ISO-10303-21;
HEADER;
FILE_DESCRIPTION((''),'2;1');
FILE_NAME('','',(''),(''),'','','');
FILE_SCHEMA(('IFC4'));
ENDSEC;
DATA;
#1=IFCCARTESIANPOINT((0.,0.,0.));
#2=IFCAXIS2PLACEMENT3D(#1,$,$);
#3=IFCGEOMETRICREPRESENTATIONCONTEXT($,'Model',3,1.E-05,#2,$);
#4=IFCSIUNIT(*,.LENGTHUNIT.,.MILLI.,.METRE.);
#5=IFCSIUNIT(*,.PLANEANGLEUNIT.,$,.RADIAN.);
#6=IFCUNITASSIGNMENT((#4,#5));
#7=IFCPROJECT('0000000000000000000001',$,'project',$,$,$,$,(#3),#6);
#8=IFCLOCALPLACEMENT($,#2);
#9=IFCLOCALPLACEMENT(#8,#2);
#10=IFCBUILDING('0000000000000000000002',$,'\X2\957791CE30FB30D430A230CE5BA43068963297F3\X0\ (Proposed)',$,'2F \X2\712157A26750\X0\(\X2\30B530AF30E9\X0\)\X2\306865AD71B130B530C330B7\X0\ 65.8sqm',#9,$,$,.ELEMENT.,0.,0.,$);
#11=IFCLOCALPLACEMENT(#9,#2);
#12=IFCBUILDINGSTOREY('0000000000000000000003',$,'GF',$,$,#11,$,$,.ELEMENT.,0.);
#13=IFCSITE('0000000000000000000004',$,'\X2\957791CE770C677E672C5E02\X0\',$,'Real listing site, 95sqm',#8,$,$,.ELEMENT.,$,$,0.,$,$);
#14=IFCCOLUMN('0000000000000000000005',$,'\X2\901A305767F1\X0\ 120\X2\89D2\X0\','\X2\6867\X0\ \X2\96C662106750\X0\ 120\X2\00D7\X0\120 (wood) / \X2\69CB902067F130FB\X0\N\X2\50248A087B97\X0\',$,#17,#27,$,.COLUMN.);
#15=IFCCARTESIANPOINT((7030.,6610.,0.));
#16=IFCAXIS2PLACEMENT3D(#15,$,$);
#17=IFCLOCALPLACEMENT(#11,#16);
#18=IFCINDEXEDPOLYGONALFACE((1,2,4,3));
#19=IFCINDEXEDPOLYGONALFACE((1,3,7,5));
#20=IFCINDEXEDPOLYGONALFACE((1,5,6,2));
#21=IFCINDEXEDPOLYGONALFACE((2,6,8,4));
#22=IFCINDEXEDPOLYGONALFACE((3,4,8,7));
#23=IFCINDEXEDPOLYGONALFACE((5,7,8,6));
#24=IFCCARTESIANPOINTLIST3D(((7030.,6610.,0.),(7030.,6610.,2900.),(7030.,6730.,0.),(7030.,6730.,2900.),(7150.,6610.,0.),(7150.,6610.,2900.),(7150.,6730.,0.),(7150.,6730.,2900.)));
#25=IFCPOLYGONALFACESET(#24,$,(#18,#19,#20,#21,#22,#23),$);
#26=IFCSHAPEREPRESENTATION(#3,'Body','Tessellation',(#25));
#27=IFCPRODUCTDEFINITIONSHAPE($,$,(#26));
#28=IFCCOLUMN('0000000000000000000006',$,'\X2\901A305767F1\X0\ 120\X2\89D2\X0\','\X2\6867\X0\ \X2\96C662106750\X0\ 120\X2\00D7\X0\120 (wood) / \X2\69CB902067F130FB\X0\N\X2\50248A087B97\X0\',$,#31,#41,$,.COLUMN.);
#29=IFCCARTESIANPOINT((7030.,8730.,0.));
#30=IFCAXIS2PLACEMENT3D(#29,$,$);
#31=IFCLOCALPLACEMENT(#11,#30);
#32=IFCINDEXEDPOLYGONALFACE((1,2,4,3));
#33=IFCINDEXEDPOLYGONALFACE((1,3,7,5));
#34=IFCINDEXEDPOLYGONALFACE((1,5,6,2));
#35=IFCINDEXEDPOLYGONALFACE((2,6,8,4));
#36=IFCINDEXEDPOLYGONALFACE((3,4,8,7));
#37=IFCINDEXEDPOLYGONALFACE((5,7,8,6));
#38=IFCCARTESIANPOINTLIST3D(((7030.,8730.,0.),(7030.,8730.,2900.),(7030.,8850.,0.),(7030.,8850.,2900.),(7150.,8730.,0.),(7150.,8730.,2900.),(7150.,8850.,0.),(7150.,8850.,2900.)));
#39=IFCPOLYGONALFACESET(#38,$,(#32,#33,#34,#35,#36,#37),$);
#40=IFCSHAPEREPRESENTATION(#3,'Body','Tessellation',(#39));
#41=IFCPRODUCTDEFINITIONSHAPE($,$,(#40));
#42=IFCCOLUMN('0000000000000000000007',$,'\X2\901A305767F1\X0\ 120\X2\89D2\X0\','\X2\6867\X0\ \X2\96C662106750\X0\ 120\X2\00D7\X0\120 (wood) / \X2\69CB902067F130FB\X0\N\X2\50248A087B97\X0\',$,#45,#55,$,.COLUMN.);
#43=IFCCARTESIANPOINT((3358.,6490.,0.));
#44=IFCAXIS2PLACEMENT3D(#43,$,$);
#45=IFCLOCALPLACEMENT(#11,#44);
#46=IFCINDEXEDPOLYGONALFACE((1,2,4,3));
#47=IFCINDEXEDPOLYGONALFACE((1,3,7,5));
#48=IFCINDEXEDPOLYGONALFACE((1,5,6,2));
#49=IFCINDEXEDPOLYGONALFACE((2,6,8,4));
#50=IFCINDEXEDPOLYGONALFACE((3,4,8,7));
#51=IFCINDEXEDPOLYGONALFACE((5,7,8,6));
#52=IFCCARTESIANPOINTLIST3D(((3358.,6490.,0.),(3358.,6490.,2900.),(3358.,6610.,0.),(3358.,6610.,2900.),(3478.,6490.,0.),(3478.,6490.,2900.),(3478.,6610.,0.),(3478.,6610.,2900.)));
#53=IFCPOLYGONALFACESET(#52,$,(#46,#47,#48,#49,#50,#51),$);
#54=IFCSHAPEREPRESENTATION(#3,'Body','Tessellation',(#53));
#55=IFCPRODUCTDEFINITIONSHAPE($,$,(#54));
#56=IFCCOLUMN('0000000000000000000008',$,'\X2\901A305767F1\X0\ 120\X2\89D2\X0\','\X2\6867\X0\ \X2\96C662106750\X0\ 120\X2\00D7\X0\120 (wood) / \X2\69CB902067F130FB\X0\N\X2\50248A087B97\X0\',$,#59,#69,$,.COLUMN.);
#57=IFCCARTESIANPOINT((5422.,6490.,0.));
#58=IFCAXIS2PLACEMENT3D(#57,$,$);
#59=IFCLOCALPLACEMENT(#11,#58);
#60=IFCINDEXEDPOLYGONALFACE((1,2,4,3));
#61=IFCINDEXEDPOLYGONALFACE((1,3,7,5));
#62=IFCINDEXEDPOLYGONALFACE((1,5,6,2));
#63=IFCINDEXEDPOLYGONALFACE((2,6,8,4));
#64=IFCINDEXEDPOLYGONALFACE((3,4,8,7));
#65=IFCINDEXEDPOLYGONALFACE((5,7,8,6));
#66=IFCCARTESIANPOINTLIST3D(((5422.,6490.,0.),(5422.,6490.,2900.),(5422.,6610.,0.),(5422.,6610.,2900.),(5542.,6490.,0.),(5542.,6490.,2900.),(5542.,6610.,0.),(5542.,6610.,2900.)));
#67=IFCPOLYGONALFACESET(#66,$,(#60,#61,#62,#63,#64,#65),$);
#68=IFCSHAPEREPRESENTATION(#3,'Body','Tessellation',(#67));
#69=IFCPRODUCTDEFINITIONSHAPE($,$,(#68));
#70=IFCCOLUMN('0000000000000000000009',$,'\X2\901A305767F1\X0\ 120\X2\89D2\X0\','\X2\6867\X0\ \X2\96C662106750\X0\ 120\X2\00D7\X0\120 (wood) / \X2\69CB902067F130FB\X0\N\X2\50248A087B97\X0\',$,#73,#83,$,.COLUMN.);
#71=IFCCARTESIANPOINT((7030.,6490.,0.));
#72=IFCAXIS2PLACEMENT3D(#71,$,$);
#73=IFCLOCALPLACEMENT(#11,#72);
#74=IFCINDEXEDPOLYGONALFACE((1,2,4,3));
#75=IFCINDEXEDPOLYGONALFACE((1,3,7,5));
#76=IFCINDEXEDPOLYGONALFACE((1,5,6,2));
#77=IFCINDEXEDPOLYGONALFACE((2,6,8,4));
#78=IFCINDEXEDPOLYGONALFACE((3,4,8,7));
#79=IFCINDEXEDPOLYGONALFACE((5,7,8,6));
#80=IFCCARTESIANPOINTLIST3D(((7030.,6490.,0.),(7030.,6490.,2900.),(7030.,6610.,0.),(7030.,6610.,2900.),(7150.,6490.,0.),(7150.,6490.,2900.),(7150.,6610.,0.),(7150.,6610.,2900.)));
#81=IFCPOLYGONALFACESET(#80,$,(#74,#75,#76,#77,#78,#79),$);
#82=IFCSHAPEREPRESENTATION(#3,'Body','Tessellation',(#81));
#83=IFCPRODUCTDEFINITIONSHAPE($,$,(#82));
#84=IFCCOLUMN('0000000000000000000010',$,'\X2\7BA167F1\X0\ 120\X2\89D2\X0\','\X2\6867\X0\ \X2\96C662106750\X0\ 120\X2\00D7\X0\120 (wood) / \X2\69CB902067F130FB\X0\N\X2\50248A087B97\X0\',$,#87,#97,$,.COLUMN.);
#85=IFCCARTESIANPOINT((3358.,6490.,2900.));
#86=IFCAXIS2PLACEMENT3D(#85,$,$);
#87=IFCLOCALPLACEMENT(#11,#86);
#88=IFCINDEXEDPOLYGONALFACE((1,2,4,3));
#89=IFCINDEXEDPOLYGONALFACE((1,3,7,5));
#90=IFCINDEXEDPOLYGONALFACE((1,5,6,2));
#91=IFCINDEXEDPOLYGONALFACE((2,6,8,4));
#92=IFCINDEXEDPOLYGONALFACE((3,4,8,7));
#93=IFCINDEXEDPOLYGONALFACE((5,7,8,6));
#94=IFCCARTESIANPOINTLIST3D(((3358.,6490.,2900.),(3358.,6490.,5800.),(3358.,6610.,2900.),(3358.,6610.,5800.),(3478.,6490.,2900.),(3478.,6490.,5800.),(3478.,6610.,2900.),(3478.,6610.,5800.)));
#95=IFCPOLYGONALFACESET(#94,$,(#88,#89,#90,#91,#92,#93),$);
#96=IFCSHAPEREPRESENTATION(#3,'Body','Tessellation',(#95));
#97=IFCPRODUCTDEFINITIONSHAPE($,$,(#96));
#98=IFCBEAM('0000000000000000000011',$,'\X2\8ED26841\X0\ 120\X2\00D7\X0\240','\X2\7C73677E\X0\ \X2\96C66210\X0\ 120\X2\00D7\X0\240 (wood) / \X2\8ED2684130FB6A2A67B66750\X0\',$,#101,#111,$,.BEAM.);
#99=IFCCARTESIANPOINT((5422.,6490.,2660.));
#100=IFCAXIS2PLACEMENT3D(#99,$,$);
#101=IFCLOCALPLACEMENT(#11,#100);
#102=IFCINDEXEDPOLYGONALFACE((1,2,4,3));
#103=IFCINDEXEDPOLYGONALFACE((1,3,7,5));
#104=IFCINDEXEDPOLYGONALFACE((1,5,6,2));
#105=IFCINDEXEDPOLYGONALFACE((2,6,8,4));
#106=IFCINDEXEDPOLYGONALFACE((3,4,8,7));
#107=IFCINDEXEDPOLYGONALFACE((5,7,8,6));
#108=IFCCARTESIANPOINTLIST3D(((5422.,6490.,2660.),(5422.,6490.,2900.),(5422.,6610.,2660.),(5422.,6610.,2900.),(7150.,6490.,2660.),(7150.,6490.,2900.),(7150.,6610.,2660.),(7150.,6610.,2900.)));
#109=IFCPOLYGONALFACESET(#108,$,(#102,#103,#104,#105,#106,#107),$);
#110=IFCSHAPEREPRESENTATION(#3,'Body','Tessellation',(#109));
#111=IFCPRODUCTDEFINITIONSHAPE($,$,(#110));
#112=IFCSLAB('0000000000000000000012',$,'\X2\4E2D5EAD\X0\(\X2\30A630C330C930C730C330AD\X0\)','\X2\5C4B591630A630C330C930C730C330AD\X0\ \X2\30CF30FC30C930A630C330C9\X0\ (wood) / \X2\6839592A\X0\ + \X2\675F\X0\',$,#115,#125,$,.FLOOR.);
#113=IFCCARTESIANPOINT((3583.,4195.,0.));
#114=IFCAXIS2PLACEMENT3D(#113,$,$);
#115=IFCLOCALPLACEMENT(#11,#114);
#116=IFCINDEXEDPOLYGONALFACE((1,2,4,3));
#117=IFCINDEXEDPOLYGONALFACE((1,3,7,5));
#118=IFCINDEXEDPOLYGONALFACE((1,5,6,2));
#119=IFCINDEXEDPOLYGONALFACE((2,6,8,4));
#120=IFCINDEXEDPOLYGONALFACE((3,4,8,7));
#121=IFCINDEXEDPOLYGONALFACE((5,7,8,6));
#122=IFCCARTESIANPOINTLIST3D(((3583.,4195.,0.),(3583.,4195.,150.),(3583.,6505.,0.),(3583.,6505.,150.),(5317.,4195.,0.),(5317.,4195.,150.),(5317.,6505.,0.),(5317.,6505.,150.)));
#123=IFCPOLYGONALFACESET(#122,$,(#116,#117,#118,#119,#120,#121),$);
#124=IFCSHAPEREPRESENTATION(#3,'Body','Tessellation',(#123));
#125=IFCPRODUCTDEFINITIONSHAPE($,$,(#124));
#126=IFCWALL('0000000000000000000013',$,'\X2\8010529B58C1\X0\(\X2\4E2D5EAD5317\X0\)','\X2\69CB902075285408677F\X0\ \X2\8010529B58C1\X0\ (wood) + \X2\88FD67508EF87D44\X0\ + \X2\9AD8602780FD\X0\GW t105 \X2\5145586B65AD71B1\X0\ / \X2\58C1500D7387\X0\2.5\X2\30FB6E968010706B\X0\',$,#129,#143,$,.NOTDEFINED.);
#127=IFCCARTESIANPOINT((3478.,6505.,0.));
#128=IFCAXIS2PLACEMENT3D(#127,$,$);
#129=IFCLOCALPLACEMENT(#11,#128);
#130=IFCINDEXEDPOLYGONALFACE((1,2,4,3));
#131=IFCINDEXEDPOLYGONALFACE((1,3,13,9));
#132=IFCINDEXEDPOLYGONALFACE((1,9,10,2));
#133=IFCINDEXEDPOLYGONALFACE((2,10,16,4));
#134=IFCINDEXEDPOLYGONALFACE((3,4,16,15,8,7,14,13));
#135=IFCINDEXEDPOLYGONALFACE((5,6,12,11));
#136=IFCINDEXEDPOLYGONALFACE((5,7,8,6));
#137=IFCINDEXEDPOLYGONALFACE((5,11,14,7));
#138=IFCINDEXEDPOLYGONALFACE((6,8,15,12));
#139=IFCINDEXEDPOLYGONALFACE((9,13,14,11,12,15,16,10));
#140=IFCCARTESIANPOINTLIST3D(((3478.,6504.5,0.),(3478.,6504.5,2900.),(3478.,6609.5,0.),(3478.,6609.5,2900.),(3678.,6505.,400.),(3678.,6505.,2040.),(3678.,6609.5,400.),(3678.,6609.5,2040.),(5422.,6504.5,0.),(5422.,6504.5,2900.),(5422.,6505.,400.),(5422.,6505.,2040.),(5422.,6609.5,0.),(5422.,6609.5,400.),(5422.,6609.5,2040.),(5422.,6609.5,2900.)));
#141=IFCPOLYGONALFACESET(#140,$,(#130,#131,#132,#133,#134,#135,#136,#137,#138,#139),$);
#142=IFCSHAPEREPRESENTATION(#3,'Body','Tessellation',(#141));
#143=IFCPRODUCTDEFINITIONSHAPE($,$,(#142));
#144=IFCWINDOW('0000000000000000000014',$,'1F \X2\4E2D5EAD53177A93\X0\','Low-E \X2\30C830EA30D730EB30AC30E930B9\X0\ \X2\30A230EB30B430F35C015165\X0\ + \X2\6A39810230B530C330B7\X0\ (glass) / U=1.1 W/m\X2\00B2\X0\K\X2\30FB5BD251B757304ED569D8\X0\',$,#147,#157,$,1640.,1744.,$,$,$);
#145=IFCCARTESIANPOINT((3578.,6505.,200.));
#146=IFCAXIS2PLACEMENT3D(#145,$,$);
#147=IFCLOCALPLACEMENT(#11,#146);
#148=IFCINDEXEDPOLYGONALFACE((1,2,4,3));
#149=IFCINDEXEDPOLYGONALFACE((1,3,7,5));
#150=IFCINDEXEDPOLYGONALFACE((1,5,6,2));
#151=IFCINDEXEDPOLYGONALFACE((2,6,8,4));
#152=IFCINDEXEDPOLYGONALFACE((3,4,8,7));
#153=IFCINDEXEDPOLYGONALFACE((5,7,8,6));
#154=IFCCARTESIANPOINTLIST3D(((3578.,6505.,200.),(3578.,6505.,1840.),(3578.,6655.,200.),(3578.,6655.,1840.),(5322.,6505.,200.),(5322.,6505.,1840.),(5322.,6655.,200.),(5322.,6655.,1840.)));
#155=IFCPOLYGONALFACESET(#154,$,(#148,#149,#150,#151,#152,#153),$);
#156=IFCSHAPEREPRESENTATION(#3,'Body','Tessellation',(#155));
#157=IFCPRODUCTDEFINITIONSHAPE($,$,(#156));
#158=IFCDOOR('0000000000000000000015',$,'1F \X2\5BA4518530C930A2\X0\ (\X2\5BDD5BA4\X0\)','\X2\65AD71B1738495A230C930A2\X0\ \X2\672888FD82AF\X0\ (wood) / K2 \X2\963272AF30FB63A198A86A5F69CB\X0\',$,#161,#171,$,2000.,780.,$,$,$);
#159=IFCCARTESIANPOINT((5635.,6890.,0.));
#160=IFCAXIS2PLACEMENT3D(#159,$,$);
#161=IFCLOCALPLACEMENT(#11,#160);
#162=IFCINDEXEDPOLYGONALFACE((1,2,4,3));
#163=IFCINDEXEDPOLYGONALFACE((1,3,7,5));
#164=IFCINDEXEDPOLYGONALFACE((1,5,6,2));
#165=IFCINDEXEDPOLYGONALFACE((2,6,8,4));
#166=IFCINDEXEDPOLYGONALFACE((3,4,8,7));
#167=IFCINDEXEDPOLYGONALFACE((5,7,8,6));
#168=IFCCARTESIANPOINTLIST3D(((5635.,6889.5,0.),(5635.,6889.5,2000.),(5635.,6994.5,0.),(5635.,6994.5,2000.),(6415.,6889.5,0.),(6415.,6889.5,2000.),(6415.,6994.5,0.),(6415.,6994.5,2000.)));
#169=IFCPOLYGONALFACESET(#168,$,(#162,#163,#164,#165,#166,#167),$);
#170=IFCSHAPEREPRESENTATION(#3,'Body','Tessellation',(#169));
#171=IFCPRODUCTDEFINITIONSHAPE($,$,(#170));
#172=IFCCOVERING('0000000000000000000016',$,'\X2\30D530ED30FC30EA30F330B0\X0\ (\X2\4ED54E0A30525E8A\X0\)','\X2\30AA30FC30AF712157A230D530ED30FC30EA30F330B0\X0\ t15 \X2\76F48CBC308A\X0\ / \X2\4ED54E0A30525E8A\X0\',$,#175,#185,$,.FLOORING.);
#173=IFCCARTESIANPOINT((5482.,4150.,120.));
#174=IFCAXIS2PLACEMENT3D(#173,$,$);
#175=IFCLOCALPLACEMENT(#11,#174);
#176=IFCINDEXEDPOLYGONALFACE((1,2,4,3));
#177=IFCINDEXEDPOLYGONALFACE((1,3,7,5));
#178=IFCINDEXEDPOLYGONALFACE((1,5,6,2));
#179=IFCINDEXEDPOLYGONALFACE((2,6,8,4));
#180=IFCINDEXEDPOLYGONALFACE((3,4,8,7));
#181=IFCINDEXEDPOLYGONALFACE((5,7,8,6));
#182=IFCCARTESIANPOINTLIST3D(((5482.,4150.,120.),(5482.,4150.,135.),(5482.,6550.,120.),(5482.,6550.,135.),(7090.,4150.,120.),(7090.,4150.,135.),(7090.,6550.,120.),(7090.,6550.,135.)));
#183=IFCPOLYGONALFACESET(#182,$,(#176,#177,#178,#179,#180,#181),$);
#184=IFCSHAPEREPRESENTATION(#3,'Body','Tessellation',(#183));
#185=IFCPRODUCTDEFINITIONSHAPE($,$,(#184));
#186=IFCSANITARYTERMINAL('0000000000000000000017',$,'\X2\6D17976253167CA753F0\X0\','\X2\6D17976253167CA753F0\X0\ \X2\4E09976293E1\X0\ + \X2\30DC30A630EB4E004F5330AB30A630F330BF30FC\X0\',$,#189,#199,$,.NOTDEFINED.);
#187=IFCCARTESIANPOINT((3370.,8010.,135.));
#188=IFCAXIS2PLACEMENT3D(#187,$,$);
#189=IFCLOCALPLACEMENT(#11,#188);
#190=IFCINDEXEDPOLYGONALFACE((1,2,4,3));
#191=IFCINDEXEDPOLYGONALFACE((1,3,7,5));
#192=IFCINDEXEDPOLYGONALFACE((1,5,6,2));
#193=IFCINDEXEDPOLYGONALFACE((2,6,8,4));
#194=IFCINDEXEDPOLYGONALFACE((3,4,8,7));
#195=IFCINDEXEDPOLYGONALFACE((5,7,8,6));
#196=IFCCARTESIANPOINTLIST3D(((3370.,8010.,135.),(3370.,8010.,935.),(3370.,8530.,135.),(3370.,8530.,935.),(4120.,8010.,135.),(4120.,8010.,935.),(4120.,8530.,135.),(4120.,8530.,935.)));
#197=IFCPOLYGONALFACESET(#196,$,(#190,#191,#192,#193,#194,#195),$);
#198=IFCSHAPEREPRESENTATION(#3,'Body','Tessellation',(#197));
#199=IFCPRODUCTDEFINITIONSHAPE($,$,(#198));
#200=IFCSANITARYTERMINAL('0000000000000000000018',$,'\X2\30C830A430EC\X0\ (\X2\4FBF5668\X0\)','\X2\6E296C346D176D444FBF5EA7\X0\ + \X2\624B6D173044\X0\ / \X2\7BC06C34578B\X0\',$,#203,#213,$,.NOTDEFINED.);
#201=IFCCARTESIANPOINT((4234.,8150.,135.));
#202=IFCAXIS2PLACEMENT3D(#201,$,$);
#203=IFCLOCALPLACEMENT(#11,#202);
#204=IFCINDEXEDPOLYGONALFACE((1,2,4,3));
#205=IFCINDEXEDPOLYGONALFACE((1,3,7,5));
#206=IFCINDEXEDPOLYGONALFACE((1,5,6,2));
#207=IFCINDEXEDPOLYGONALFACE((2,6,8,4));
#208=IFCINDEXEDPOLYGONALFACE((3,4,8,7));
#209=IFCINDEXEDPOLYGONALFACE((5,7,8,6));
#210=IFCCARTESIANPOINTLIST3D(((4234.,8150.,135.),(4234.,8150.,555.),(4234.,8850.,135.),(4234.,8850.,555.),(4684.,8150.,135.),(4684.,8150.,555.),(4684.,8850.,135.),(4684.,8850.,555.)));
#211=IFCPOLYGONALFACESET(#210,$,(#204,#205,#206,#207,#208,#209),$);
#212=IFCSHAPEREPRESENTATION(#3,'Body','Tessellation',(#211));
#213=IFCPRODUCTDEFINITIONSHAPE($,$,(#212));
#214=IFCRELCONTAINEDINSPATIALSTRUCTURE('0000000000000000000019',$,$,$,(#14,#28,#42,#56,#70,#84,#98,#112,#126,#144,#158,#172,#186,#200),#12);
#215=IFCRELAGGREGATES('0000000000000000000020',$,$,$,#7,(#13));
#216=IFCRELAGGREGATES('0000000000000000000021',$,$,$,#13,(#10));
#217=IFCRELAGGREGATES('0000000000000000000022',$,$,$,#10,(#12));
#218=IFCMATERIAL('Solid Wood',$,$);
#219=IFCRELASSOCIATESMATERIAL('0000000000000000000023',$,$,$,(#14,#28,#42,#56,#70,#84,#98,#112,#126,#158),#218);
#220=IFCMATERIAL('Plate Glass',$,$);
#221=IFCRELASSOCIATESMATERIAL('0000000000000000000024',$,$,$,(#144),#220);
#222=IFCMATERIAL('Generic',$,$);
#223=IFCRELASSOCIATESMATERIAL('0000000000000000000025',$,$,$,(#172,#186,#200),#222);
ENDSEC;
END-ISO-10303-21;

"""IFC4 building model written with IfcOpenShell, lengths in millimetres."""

from ifc_helpers import new_model, si_unit, frame, frame_2d, origin, place, context, project, spatial, rectangle, extrude, material, element, fill, save


model = new_model("IFC4")

# Units and contexts
model_context = context("Model", 3, precision=1e-05, world=origin())
ifc_project = project(units=[si_unit("LENGTHUNIT", "METRE", prefix="MILLI"), si_unit("PLANEANGLEUNIT", "RADIAN")], contexts=[model_context])

# Site, building, storey
site_placement = place(None, origin())
site = spatial("IfcSite", under=ifc_project, at=site_placement, Name="長野県松本市", ObjectType="Real listing site, 95sqm", CompositionType="ELEMENT", RefElevation=0.0)
building_placement = place(site_placement, origin())
building = spatial("IfcBuilding", under=site, at=building_placement, Name="長野・ピアノ室と防音 (Proposed)", ObjectType="2F 無垢材(サクラ)と断熱サッシ 65.8sqm", CompositionType="ELEMENT", ElevationOfRefHeight=0.0, ElevationOfTerrain=0.0)
storey_placement = place(building_placement, origin())
storey = spatial("IfcBuildingStorey", under=building, at=storey_placement, Name="GF", CompositionType="ELEMENT", Elevation=0.0)

# Columns
ifc_material_1 = material(Name="Solid Wood")
column_1_placement = place(storey_placement, frame((7030.0, 6610.0, 0.0)))
element("IfcColumn", 1, at=column_1_placement, inside=storey, material=ifc_material_1, Name="通し柱 120角", Description="桧 集成材 120×120 (wood) / 構造柱・N値計算", PredefinedType="COLUMN", context=model_context, shape_type="SweptSolid", body=[
    extrude(rectangle(XDim=120.0, YDim=120.0, at=frame_2d((60.0, 60.0))), frame((7030.0, 6610.0, 0.0)), (0.0, 0.0, 1.0), 2900.0),
])
column_2_placement = place(storey_placement, frame((7030.0, 8730.0, 0.0)))
element("IfcColumn", 2, at=column_2_placement, inside=storey, material=ifc_material_1, Name="通し柱 120角", Description="桧 集成材 120×120 (wood) / 構造柱・N値計算", PredefinedType="COLUMN", context=model_context, shape_type="SweptSolid", body=[
    extrude(rectangle(XDim=120.0, YDim=120.0, at=frame_2d((60.0, 60.0))), frame((7030.0, 8730.0, 0.0)), (0.0, 0.0, 1.0), 2900.0),
])
column_3_placement = place(storey_placement, frame((3358.0, 6490.0, 0.0)))
element("IfcColumn", 3, at=column_3_placement, inside=storey, material=ifc_material_1, Name="通し柱 120角", Description="桧 集成材 120×120 (wood) / 構造柱・N値計算", PredefinedType="COLUMN", context=model_context, shape_type="SweptSolid", body=[
    extrude(rectangle(XDim=120.0, YDim=120.0, at=frame_2d((60.0, 60.0))), frame((3358.0, 6490.0, 0.0)), (0.0, 0.0, 1.0), 2900.0),
])
column_4_placement = place(storey_placement, frame((5422.0, 6490.0, 0.0)))
element("IfcColumn", 4, at=column_4_placement, inside=storey, material=ifc_material_1, Name="通し柱 120角", Description="桧 集成材 120×120 (wood) / 構造柱・N値計算", PredefinedType="COLUMN", context=model_context, shape_type="SweptSolid", body=[
    extrude(rectangle(XDim=120.0, YDim=120.0, at=frame_2d((60.0, 60.0))), frame((5422.0, 6490.0, 0.0)), (0.0, 0.0, 1.0), 2900.0),
])
column_5_placement = place(storey_placement, frame((7030.0, 6490.0, 0.0)))
element("IfcColumn", 5, at=column_5_placement, inside=storey, material=ifc_material_1, Name="通し柱 120角", Description="桧 集成材 120×120 (wood) / 構造柱・N値計算", PredefinedType="COLUMN", context=model_context, shape_type="SweptSolid", body=[
    extrude(rectangle(XDim=120.0, YDim=120.0, at=frame_2d((60.0, 60.0))), frame((7030.0, 6490.0, 0.0)), (0.0, 0.0, 1.0), 2900.0),
])
column_6_placement = place(storey_placement, frame((3358.0, 6490.0, 2900.0)))
element("IfcColumn", 6, at=column_6_placement, inside=storey, material=ifc_material_1, Name="管柱 120角", Description="桧 集成材 120×120 (wood) / 構造柱・N値計算", PredefinedType="COLUMN", context=model_context, shape_type="SweptSolid", body=[
    extrude(rectangle(XDim=120.0, YDim=120.0, at=frame_2d((60.0, 60.0))), frame((3358.0, 6490.0, 2900.0)), (0.0, 0.0, 1.0), 2900.0),
])

# Beam
beam_1_placement = place(storey_placement, frame((5422.0, 6490.0, 2660.0)))
element("IfcBeam", 7, at=beam_1_placement, inside=storey, material=ifc_material_1, Name="軒桁 120×240", Description="米松 集成 120×240 (wood) / 軒桁・横架材", PredefinedType="BEAM", context=model_context, shape_type="SweptSolid", body=[
    extrude(rectangle(XDim=1728.0, YDim=120.0, at=frame_2d((864.0, 60.0))), frame((5422.0, 6490.0, 2660.0)), (0.0, 0.0, 1.0), 240.0),
])

# Slab
slab_placement = place(storey_placement, frame((3583.0, 4195.0, 0.0)))
element("IfcSlab", 8, at=slab_placement, inside=storey, material=ifc_material_1, Name="中庭(ウッドデッキ)", Description="屋外ウッドデッキ ハードウッド (wood) / 根太 + 束", PredefinedType="FLOOR", context=model_context, shape_type="SweptSolid", body=[
    extrude(rectangle(XDim=1734.0, YDim=2310.0, at=frame_2d((867.0, 1155.0))), frame((3583.0, 4195.0, 0.0)), (0.0, 0.0, 1.0), 150.0),
])

# Wall, opening, window
wall_1_placement = place(storey_placement, frame((3478.0, 6505.0, 0.0)))
wall_1 = element("IfcWall", 9, at=wall_1_placement, inside=storey, material=ifc_material_1, Name="耐力壁(中庭北)", Description="構造用合板 耐力壁 (wood) + 製材軸組 + 高性能GW t105 充填断熱 / 壁倍率2.5・準耐火", PredefinedType="NOTDEFINED", context=model_context, shape_type="SweptSolid", body=[
    extrude(rectangle(XDim=1944.0, YDim=105.0, at=frame_2d((972.0, 52.0))), frame((3478.0, 6505.0, 0.0)), (0.0, 0.0, 1.0), 2900.0),
])
opening_placement = place(storey_placement, frame((3578.0, 6505.0, 200.0)))
opening = element("IfcOpeningElement", 10, at=opening_placement, cuts=wall_1, PredefinedType="NOTDEFINED", context=model_context, shape_type="SweptSolid", body=[
    extrude(rectangle(XDim=1744.0, YDim=150.0, at=frame_2d((872.0, 75.0))), frame((3578.0, 6505.0, 200.0)), (0.0, 0.0, 1.0), 1640.0),
])
ifc_material_2 = material(Name="Plate Glass")
window_placement = place(storey_placement, frame((3578.0, 6505.0, 200.0)))
window = element("IfcWindow", 11, at=window_placement, inside=storey, material=ifc_material_2, Name="1F 中庭北窓", Description="Low-E トリプルガラス アルゴン封入 + 樹脂サッシ (glass) / U=1.1 W/m²K・寒冷地仕様", OverallHeight=1640.0, OverallWidth=1744.0, context=model_context, shape_type="SweptSolid", body=[
    extrude(rectangle(XDim=1744.0, YDim=150.0, at=frame_2d((872.0, 75.0))), frame((3578.0, 6505.0, 200.0)), (0.0, 0.0, 1.0), 1640.0),
])
fill(opening, window)

# Door
door_placement = place(storey_placement, frame((5635.0, 6890.0, 0.0)))
element("IfcDoor", 12, at=door_placement, inside=storey, material=ifc_material_1, Name="1F 室内ドア (寝室)", Description="断熱玄関ドア 木製芯 (wood) / K2 防犯・採風機構", OverallHeight=2000.0, OverallWidth=780.0, context=model_context, shape_type="SweptSolid", body=[
    extrude(rectangle(XDim=780.0, YDim=105.0, at=frame_2d((390.0, 52.0))), frame((5635.0, 6890.0, 0.0)), (0.0, 0.0, 1.0), 2000.0),
])

# Covering
ifc_material_3 = material(Name="Generic")
covering_placement = place(storey_placement, frame((5482.0, 4150.0, 120.0)))
element("IfcCovering", 13, at=covering_placement, inside=storey, material=ifc_material_3, Name="フローリング (仕上げ床)", Description="オーク無垢フローリング t15 直貼り / 仕上げ床", PredefinedType="FLOORING", context=model_context, shape_type="SweptSolid", body=[
    extrude(rectangle(XDim=1608.0, YDim=2400.0, at=frame_2d((804.0, 1200.0))), frame((5482.0, 4150.0, 120.0)), (0.0, 0.0, 1.0), 15.0),
])

# Sanitary terminals
sanitary_terminal_1_placement = place(storey_placement, frame((3370.0, 8010.0, 135.0)))
element("IfcSanitaryTerminal", 14, at=sanitary_terminal_1_placement, inside=storey, material=ifc_material_3, Name="洗面化粧台", Description="洗面化粧台 三面鏡 + ボウル一体カウンター", PredefinedType="NOTDEFINED", context=model_context, shape_type="SweptSolid", body=[
    extrude(rectangle(XDim=750.0, YDim=520.0, at=frame_2d((375.0, 260.0))), frame((3370.0, 8010.0, 135.0)), (0.0, 0.0, 1.0), 800.0),
])
sanitary_terminal_2_placement = place(storey_placement, frame((4234.0, 8150.0, 135.0)))
element("IfcSanitaryTerminal", 15, at=sanitary_terminal_2_placement, inside=storey, material=ifc_material_3, Name="トイレ (便器)", Description="温水洗浄便座 + 手洗い / 節水型", PredefinedType="NOTDEFINED", context=model_context, shape_type="SweptSolid", body=[
    extrude(rectangle(XDim=450.0, YDim=700.0, at=frame_2d((225.0, 350.0))), frame((4234.0, 8150.0, 135.0)), (0.0, 0.0, 1.0), 420.0),
])

save(model, "model.ifc")
